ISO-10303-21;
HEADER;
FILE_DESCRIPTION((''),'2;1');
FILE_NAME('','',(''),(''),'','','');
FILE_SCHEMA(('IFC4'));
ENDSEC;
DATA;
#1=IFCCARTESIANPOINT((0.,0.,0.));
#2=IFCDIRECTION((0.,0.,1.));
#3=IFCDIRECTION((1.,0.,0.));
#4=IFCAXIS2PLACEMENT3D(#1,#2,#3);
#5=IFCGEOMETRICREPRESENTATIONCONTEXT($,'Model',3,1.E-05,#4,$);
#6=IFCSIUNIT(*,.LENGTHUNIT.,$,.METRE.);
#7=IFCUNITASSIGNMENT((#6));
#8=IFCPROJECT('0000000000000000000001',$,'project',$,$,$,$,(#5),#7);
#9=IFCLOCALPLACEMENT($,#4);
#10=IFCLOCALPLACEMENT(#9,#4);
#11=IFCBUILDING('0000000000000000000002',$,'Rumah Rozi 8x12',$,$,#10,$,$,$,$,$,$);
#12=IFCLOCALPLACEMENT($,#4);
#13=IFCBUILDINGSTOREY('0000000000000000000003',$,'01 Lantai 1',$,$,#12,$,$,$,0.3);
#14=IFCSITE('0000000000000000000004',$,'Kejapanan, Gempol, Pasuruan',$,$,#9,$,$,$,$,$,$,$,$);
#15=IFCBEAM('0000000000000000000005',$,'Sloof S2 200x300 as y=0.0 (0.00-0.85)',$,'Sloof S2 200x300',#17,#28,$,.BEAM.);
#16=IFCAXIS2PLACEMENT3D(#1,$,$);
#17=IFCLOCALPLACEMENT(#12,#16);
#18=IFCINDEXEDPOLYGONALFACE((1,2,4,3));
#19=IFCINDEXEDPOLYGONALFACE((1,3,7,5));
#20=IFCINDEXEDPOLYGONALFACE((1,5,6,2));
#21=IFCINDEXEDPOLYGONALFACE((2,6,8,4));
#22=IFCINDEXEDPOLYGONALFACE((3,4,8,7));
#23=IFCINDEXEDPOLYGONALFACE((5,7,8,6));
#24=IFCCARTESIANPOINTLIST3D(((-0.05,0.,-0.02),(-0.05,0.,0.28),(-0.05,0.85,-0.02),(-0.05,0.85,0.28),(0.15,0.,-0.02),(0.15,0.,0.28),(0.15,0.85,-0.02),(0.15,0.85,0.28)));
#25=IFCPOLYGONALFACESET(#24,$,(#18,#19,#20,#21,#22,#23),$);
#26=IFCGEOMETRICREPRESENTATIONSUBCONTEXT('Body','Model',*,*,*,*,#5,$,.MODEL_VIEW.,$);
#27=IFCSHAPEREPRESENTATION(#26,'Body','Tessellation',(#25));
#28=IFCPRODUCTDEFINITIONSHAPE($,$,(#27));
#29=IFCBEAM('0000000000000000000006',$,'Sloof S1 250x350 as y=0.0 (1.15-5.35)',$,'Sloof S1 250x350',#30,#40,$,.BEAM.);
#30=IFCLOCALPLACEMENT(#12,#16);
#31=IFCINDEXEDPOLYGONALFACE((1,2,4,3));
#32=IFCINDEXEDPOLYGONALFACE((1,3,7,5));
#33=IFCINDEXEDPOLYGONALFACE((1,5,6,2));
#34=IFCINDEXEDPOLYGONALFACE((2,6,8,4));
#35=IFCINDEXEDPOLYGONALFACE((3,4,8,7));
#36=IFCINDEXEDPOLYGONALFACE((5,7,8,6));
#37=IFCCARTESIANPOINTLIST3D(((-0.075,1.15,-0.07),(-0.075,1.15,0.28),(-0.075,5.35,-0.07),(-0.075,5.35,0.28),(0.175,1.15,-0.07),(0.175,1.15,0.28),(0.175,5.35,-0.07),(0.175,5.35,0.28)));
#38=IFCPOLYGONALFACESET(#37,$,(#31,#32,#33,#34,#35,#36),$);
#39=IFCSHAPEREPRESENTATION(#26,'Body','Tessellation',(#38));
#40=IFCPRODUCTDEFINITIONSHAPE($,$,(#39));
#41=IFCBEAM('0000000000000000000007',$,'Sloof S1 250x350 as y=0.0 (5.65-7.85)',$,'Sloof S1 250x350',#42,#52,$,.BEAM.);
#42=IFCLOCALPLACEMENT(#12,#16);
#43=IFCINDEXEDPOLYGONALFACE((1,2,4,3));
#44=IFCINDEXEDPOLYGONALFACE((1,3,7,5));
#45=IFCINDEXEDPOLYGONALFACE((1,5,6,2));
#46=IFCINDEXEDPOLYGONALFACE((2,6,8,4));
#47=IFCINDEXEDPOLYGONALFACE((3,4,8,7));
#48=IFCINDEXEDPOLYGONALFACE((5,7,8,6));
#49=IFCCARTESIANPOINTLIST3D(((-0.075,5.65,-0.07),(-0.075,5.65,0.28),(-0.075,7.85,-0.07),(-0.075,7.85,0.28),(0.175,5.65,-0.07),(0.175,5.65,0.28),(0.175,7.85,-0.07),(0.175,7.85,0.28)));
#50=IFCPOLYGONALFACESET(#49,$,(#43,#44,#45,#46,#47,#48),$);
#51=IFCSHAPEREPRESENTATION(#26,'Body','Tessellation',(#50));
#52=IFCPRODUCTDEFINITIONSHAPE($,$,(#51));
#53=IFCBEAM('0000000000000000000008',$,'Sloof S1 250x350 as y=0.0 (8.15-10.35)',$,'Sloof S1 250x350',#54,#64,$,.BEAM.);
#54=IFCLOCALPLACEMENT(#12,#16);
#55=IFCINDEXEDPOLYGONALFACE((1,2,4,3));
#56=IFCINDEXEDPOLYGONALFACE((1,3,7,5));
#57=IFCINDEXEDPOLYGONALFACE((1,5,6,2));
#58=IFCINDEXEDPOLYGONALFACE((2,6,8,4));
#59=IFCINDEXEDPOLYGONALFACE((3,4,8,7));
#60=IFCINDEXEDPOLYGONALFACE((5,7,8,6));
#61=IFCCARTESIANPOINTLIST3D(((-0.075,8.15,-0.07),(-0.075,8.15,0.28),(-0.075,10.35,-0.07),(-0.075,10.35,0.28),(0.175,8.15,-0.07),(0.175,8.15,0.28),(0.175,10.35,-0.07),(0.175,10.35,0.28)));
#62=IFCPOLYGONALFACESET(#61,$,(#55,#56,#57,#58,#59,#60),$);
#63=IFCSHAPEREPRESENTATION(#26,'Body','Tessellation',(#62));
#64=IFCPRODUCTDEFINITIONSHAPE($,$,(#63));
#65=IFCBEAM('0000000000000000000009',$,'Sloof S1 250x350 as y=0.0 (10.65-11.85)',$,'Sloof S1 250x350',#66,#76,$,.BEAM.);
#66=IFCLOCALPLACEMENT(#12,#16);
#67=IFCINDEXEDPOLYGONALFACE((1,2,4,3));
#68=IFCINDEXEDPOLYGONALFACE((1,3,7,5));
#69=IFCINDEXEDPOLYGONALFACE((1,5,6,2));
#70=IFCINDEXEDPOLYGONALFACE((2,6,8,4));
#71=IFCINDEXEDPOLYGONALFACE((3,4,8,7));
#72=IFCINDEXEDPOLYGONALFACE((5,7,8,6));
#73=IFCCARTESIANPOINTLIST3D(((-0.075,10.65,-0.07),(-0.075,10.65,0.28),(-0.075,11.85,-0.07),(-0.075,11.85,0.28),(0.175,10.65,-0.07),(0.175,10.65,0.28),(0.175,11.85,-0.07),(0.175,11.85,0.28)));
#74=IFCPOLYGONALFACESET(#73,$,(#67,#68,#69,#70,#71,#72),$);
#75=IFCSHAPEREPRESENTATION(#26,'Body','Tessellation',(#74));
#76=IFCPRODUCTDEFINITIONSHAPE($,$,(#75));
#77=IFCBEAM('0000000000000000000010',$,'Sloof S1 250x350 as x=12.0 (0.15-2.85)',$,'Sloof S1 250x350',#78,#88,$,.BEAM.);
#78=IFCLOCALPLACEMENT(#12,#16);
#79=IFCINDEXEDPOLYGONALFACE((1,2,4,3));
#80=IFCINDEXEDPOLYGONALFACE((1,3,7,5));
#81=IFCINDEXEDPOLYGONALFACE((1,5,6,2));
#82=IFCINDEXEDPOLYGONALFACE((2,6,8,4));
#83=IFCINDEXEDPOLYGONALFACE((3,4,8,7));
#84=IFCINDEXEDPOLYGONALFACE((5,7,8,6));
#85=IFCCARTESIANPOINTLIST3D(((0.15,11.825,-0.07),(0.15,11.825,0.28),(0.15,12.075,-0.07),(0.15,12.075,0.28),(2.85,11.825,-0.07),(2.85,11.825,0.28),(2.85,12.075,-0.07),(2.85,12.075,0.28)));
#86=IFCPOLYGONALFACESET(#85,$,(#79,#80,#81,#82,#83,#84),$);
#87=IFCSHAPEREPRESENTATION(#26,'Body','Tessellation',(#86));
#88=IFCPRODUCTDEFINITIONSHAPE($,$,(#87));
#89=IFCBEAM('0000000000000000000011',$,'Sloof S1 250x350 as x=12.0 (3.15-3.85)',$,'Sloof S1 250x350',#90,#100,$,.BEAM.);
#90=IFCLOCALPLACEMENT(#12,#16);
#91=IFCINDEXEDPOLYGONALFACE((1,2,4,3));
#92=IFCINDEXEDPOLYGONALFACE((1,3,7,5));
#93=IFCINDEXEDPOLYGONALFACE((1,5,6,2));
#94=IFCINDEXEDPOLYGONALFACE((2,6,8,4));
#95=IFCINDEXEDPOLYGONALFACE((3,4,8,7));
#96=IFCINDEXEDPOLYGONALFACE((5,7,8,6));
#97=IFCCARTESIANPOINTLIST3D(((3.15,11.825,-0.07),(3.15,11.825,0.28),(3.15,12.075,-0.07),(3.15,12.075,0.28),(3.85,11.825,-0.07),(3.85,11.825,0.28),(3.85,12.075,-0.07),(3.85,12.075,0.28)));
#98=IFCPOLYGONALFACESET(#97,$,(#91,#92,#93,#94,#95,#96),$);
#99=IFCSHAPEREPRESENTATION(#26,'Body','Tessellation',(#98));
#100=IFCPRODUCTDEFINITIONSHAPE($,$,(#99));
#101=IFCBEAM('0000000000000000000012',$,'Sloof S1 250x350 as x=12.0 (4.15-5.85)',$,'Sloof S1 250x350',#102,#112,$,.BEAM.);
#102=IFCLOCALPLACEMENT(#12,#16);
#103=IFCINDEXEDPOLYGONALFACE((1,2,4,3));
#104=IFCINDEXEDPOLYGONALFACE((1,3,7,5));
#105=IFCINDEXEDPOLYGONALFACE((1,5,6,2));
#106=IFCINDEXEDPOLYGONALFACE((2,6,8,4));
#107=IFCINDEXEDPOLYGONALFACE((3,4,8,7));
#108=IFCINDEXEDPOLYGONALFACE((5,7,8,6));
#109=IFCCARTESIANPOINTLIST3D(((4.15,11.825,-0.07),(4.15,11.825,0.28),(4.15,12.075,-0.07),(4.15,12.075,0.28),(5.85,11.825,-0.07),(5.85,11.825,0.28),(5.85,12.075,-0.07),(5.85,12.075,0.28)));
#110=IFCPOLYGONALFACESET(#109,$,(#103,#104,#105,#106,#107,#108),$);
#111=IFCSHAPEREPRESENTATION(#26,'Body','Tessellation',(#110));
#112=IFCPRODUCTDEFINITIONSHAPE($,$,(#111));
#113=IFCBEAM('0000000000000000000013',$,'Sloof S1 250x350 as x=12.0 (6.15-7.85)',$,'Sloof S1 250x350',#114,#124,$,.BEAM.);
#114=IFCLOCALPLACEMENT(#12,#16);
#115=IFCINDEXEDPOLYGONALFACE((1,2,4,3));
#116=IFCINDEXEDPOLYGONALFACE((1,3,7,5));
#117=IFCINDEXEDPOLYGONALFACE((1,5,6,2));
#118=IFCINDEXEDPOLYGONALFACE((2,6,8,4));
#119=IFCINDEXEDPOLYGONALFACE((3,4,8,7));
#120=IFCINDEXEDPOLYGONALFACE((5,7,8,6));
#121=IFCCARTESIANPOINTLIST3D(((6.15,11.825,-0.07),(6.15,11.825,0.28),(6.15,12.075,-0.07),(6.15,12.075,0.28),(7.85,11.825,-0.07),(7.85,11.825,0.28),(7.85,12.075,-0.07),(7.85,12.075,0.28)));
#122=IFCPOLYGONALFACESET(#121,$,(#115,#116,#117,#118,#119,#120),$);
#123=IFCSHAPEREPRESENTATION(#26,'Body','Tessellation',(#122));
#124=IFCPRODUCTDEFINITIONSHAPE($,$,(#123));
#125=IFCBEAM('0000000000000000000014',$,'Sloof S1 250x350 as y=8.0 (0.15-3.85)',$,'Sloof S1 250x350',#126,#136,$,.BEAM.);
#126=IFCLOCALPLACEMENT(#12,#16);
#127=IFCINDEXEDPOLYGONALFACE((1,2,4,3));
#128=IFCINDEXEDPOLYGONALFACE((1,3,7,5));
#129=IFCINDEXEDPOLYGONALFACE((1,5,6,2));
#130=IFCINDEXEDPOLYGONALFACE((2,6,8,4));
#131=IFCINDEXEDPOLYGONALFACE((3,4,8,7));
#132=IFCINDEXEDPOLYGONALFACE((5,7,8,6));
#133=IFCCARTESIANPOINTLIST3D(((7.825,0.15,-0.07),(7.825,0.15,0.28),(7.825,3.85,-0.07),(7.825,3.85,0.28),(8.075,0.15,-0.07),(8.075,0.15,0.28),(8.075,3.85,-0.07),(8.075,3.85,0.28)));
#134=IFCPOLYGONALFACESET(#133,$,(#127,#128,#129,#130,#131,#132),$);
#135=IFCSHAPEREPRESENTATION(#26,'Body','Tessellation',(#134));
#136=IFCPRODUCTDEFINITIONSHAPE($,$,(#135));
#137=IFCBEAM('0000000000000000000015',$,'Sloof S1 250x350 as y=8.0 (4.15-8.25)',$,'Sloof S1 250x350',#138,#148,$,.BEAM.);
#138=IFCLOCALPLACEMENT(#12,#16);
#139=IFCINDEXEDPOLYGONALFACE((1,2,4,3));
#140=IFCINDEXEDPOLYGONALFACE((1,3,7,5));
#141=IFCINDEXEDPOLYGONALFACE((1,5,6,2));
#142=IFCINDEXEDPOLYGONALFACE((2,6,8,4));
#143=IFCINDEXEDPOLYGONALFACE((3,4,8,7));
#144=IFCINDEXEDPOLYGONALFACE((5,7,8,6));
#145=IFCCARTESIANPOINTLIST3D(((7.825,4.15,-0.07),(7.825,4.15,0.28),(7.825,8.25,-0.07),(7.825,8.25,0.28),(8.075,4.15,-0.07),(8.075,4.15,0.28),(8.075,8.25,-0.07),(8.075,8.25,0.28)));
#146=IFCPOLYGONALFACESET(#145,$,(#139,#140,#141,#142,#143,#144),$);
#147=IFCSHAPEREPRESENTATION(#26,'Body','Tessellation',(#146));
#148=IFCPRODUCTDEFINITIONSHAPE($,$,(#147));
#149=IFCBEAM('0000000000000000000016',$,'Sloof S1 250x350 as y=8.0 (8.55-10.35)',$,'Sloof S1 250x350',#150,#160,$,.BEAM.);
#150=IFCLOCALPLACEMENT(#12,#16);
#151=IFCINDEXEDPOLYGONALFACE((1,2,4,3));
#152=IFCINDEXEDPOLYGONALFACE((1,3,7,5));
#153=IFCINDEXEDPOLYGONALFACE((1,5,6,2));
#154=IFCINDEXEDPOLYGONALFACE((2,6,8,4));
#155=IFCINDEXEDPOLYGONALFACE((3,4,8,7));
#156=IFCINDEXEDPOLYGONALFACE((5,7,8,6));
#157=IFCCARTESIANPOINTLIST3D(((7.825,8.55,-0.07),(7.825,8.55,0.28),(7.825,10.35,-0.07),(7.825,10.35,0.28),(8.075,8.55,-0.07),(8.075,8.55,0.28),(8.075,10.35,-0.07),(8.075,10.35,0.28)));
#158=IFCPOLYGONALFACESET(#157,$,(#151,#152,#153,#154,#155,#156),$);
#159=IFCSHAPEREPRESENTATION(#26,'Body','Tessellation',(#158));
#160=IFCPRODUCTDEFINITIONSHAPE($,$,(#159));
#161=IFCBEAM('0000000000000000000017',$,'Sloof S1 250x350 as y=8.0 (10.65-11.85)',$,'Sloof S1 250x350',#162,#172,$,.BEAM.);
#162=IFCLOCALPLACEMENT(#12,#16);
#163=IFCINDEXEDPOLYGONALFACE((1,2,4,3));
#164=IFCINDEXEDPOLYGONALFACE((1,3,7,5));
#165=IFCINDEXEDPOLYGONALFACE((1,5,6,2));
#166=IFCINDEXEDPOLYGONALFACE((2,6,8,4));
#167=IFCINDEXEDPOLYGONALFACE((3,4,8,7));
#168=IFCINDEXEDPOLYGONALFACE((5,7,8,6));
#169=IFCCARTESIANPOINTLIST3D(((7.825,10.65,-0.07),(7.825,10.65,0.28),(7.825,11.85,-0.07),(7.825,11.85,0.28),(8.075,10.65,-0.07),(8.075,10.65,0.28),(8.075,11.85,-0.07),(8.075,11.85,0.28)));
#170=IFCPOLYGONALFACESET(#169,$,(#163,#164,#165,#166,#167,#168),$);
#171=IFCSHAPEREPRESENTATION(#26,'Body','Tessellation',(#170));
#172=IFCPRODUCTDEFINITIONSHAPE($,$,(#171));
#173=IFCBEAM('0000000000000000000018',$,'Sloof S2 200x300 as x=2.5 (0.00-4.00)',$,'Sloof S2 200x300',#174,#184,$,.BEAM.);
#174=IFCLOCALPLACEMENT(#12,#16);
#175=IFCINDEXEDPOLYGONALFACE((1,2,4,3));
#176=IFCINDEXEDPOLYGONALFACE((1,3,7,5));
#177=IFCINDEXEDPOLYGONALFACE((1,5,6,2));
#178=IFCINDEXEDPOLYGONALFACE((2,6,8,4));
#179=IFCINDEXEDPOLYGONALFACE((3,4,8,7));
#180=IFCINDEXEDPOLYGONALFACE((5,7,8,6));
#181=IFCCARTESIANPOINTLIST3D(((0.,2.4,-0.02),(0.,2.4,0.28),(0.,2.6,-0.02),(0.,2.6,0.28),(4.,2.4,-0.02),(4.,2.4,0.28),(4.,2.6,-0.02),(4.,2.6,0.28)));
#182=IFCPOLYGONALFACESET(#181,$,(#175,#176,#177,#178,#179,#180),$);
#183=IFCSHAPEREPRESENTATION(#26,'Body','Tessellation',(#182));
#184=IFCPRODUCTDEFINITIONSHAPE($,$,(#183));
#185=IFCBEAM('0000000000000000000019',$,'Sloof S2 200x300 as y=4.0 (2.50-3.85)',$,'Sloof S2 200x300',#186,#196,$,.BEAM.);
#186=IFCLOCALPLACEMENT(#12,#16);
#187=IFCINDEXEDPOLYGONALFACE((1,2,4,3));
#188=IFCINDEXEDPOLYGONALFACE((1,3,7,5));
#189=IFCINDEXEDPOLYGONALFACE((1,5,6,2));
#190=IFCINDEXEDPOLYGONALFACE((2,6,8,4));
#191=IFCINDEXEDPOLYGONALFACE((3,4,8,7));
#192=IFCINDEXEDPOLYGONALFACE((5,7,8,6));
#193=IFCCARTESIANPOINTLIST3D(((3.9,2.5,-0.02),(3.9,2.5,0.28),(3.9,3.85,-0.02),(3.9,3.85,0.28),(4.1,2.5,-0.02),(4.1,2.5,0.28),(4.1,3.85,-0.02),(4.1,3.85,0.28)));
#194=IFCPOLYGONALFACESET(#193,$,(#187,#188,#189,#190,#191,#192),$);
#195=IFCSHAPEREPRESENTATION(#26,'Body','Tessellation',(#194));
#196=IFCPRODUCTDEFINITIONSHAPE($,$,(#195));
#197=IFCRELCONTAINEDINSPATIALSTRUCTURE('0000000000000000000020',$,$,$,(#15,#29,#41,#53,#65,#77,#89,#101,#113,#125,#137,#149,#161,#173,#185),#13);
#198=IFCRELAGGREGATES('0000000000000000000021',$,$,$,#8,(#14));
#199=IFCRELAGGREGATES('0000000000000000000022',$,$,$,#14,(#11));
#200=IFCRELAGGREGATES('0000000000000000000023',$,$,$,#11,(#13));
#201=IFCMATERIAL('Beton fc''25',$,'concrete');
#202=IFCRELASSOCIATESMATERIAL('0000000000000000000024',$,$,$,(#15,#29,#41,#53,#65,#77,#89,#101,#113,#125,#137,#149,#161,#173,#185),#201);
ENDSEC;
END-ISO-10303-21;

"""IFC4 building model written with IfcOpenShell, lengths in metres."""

from ifc_helpers import new_model, si_unit, frame, origin_with_axes, place, context, subcontext, project, spatial, line, indexed_curve, outline, extrude, material, element, save


model = new_model("IFC4")

# Units and contexts
model_context = context("Model", 3, precision=1e-05, world=origin_with_axes())
body_context = subcontext(model_context, "Body", "Model", "MODEL_VIEW")
ifc_project = project(units=[si_unit("LENGTHUNIT", "METRE")], contexts=[model_context])

# Site, building, storey
site_placement = place(None, origin_with_axes())
site = spatial("IfcSite", under=ifc_project, at=site_placement, Name="Kejapanan, Gempol, Pasuruan")
building_placement = place(site_placement, origin_with_axes())
building = spatial("IfcBuilding", under=site, at=building_placement, Name="Rumah Rozi 8x12")
storey_placement = place(None, origin_with_axes())
storey = spatial("IfcBuildingStorey", under=building, at=storey_placement, Name="01 Lantai 1", Elevation=0.3)

# Beams
ifc_material = material(Name="Beton fc'25", Category="concrete")
beam_1_placement = place(storey_placement, origin_with_axes())
element("IfcBeam", 1, at=beam_1_placement, inside=storey, material=ifc_material, Name="Sloof S2 200x300 as y=0.0 (0.00-0.85)", ObjectType="Sloof S2 200x300", PredefinedType="BEAM", context=body_context, shape_type="SweptSolid", body=[
    extrude(outline(indexed_curve([(-0.05, 0.0), (0.15, 0.0), (0.15, 0.85), (-0.05, 0.85)], segments=[line(1, 2, 3, 4, 1)])), frame((0.0, 0.0, -0.02), z_axis=(0.0, 0.0, 1.0), x_axis=(1.0, 0.0, 0.0)), (0.0, 0.0, 1.0), 0.3),
])
beam_2_placement = place(storey_placement, origin_with_axes())
element("IfcBeam", 2, at=beam_2_placement, inside=storey, material=ifc_material, Name="Sloof S1 250x350 as y=0.0 (1.15-5.35)", ObjectType="Sloof S1 250x350", PredefinedType="BEAM", context=body_context, shape_type="SweptSolid", body=[
    extrude(outline(indexed_curve([(-0.075, 1.15), (0.175, 1.15), (0.175, 5.35), (-0.075, 5.35)], segments=[line(1, 2, 3, 4, 1)])), frame((0.0, 0.0, -0.07), z_axis=(0.0, 0.0, 1.0), x_axis=(1.0, 0.0, 0.0)), (0.0, 0.0, 1.0), 0.35),
])
beam_3_placement = place(storey_placement, origin_with_axes())
element("IfcBeam", 3, at=beam_3_placement, inside=storey, material=ifc_material, Name="Sloof S1 250x350 as y=0.0 (5.65-7.85)", ObjectType="Sloof S1 250x350", PredefinedType="BEAM", context=body_context, shape_type="SweptSolid", body=[
    extrude(outline(indexed_curve([(-0.075, 5.65), (0.175, 5.65), (0.175, 7.85), (-0.075, 7.85)], segments=[line(1, 2, 3, 4, 1)])), frame((0.0, 0.0, -0.07), z_axis=(0.0, 0.0, 1.0), x_axis=(1.0, 0.0, 0.0)), (0.0, 0.0, 1.0), 0.35),
])
beam_4_placement = place(storey_placement, origin_with_axes())
element("IfcBeam", 4, at=beam_4_placement, inside=storey, material=ifc_material, Name="Sloof S1 250x350 as y=0.0 (8.15-10.35)", ObjectType="Sloof S1 250x350", PredefinedType="BEAM", context=body_context, shape_type="SweptSolid", body=[
    extrude(outline(indexed_curve([(-0.075, 8.15), (0.175, 8.15), (0.175, 10.35), (-0.075, 10.35)], segments=[line(1, 2, 3, 4, 1)])), frame((0.0, 0.0, -0.07), z_axis=(0.0, 0.0, 1.0), x_axis=(1.0, 0.0, 0.0)), (0.0, 0.0, 1.0), 0.35),
])
beam_5_placement = place(storey_placement, origin_with_axes())
element("IfcBeam", 5, at=beam_5_placement, inside=storey, material=ifc_material, Name="Sloof S1 250x350 as y=0.0 (10.65-11.85)", ObjectType="Sloof S1 250x350", PredefinedType="BEAM", context=body_context, shape_type="SweptSolid", body=[
    extrude(outline(indexed_curve([(-0.075, 10.65), (0.175, 10.65), (0.175, 11.85), (-0.075, 11.85)], segments=[line(1, 2, 3, 4, 1)])), frame((0.0, 0.0, -0.07), z_axis=(0.0, 0.0, 1.0), x_axis=(1.0, 0.0, 0.0)), (0.0, 0.0, 1.0), 0.35),
])
beam_6_placement = place(storey_placement, origin_with_axes())
element("IfcBeam", 6, at=beam_6_placement, inside=storey, material=ifc_material, Name="Sloof S1 250x350 as x=12.0 (0.15-2.85)", ObjectType="Sloof S1 250x350", PredefinedType="BEAM", context=body_context, shape_type="SweptSolid", body=[
    extrude(outline(indexed_curve([(0.15, 11.825), (2.85, 11.825), (2.85, 12.075), (0.15, 12.075)], segments=[line(1, 2, 3, 4, 1)])), frame((0.0, 0.0, -0.07), z_axis=(0.0, 0.0, 1.0), x_axis=(1.0, 0.0, 0.0)), (0.0, 0.0, 1.0), 0.35),
])
beam_7_placement = place(storey_placement, origin_with_axes())
element("IfcBeam", 7, at=beam_7_placement, inside=storey, material=ifc_material, Name="Sloof S1 250x350 as x=12.0 (3.15-3.85)", ObjectType="Sloof S1 250x350", PredefinedType="BEAM", context=body_context, shape_type="SweptSolid", body=[
    extrude(outline(indexed_curve([(3.15, 11.825), (3.85, 11.825), (3.85, 12.075), (3.15, 12.075)], segments=[line(1, 2, 3, 4, 1)])), frame((0.0, 0.0, -0.07), z_axis=(0.0, 0.0, 1.0), x_axis=(1.0, 0.0, 0.0)), (0.0, 0.0, 1.0), 0.35),
])
beam_8_placement = place(storey_placement, origin_with_axes())
element("IfcBeam", 8, at=beam_8_placement, inside=storey, material=ifc_material, Name="Sloof S1 250x350 as x=12.0 (4.15-5.85)", ObjectType="Sloof S1 250x350", PredefinedType="BEAM", context=body_context, shape_type="SweptSolid", body=[
    extrude(outline(indexed_curve([(4.15, 11.825), (5.85, 11.825), (5.85, 12.075), (4.15, 12.075)], segments=[line(1, 2, 3, 4, 1)])), frame((0.0, 0.0, -0.07), z_axis=(0.0, 0.0, 1.0), x_axis=(1.0, 0.0, 0.0)), (0.0, 0.0, 1.0), 0.35),
])
beam_9_placement = place(storey_placement, origin_with_axes())
element("IfcBeam", 9, at=beam_9_placement, inside=storey, material=ifc_material, Name="Sloof S1 250x350 as x=12.0 (6.15-7.85)", ObjectType="Sloof S1 250x350", PredefinedType="BEAM", context=body_context, shape_type="SweptSolid", body=[
    extrude(outline(indexed_curve([(6.15, 11.825), (7.85, 11.825), (7.85, 12.075), (6.15, 12.075)], segments=[line(1, 2, 3, 4, 1)])), frame((0.0, 0.0, -0.07), z_axis=(0.0, 0.0, 1.0), x_axis=(1.0, 0.0, 0.0)), (0.0, 0.0, 1.0), 0.35),
])
beam_10_placement = place(storey_placement, origin_with_axes())
element("IfcBeam", 10, at=beam_10_placement, inside=storey, material=ifc_material, Name="Sloof S1 250x350 as y=8.0 (0.15-3.85)", ObjectType="Sloof S1 250x350", PredefinedType="BEAM", context=body_context, shape_type="SweptSolid", body=[
    extrude(outline(indexed_curve([(7.825, 0.15), (8.075, 0.15), (8.075, 3.85), (7.825, 3.85)], segments=[line(1, 2, 3, 4, 1)])), frame((0.0, 0.0, -0.07), z_axis=(0.0, 0.0, 1.0), x_axis=(1.0, 0.0, 0.0)), (0.0, 0.0, 1.0), 0.35),
])
beam_11_placement = place(storey_placement, origin_with_axes())
element("IfcBeam", 11, at=beam_11_placement, inside=storey, material=ifc_material, Name="Sloof S1 250x350 as y=8.0 (4.15-8.25)", ObjectType="Sloof S1 250x350", PredefinedType="BEAM", context=body_context, shape_type="SweptSolid", body=[
    extrude(outline(indexed_curve([(7.825, 4.15), (8.075, 4.15), (8.075, 8.25), (7.825, 8.25)], segments=[line(1, 2, 3, 4, 1)])), frame((0.0, 0.0, -0.07), z_axis=(0.0, 0.0, 1.0), x_axis=(1.0, 0.0, 0.0)), (0.0, 0.0, 1.0), 0.35),
])
beam_12_placement = place(storey_placement, origin_with_axes())
element("IfcBeam", 12, at=beam_12_placement, inside=storey, material=ifc_material, Name="Sloof S1 250x350 as y=8.0 (8.55-10.35)", ObjectType="Sloof S1 250x350", PredefinedType="BEAM", context=body_context, shape_type="SweptSolid", body=[
    extrude(outline(indexed_curve([(7.825, 8.55), (8.075, 8.55), (8.075, 10.35), (7.825, 10.35)], segments=[line(1, 2, 3, 4, 1)])), frame((0.0, 0.0, -0.07), z_axis=(0.0, 0.0, 1.0), x_axis=(1.0, 0.0, 0.0)), (0.0, 0.0, 1.0), 0.35),
])
beam_13_placement = place(storey_placement, origin_with_axes())
element("IfcBeam", 13, at=beam_13_placement, inside=storey, material=ifc_material, Name="Sloof S1 250x350 as y=8.0 (10.65-11.85)", ObjectType="Sloof S1 250x350", PredefinedType="BEAM", context=body_context, shape_type="SweptSolid", body=[
    extrude(outline(indexed_curve([(7.825, 10.65), (8.075, 10.65), (8.075, 11.85), (7.825, 11.85)], segments=[line(1, 2, 3, 4, 1)])), frame((0.0, 0.0, -0.07), z_axis=(0.0, 0.0, 1.0), x_axis=(1.0, 0.0, 0.0)), (0.0, 0.0, 1.0), 0.35),
])
beam_14_placement = place(storey_placement, origin_with_axes())
element("IfcBeam", 14, at=beam_14_placement, inside=storey, material=ifc_material, Name="Sloof S2 200x300 as x=2.5 (0.00-4.00)", ObjectType="Sloof S2 200x300", PredefinedType="BEAM", context=body_context, shape_type="SweptSolid", body=[
    extrude(outline(indexed_curve([(0.0, 2.4), (4.0, 2.4), (4.0, 2.6), (0.0, 2.6)], segments=[line(1, 2, 3, 4, 1)])), frame((0.0, 0.0, -0.02), z_axis=(0.0, 0.0, 1.0), x_axis=(1.0, 0.0, 0.0)), (0.0, 0.0, 1.0), 0.3),
])
beam_15_placement = place(storey_placement, origin_with_axes())
element("IfcBeam", 15, at=beam_15_placement, inside=storey, material=ifc_material, Name="Sloof S2 200x300 as y=4.0 (2.50-3.85)", ObjectType="Sloof S2 200x300", PredefinedType="BEAM", context=body_context, shape_type="SweptSolid", body=[
    extrude(outline(indexed_curve([(3.9, 2.5), (4.1, 2.5), (4.1, 3.85), (3.9, 3.85)], segments=[line(1, 2, 3, 4, 1)])), frame((0.0, 0.0, -0.02), z_axis=(0.0, 0.0, 1.0), x_axis=(1.0, 0.0, 0.0)), (0.0, 0.0, 1.0), 0.3),
])

save(model, "model.ifc")
